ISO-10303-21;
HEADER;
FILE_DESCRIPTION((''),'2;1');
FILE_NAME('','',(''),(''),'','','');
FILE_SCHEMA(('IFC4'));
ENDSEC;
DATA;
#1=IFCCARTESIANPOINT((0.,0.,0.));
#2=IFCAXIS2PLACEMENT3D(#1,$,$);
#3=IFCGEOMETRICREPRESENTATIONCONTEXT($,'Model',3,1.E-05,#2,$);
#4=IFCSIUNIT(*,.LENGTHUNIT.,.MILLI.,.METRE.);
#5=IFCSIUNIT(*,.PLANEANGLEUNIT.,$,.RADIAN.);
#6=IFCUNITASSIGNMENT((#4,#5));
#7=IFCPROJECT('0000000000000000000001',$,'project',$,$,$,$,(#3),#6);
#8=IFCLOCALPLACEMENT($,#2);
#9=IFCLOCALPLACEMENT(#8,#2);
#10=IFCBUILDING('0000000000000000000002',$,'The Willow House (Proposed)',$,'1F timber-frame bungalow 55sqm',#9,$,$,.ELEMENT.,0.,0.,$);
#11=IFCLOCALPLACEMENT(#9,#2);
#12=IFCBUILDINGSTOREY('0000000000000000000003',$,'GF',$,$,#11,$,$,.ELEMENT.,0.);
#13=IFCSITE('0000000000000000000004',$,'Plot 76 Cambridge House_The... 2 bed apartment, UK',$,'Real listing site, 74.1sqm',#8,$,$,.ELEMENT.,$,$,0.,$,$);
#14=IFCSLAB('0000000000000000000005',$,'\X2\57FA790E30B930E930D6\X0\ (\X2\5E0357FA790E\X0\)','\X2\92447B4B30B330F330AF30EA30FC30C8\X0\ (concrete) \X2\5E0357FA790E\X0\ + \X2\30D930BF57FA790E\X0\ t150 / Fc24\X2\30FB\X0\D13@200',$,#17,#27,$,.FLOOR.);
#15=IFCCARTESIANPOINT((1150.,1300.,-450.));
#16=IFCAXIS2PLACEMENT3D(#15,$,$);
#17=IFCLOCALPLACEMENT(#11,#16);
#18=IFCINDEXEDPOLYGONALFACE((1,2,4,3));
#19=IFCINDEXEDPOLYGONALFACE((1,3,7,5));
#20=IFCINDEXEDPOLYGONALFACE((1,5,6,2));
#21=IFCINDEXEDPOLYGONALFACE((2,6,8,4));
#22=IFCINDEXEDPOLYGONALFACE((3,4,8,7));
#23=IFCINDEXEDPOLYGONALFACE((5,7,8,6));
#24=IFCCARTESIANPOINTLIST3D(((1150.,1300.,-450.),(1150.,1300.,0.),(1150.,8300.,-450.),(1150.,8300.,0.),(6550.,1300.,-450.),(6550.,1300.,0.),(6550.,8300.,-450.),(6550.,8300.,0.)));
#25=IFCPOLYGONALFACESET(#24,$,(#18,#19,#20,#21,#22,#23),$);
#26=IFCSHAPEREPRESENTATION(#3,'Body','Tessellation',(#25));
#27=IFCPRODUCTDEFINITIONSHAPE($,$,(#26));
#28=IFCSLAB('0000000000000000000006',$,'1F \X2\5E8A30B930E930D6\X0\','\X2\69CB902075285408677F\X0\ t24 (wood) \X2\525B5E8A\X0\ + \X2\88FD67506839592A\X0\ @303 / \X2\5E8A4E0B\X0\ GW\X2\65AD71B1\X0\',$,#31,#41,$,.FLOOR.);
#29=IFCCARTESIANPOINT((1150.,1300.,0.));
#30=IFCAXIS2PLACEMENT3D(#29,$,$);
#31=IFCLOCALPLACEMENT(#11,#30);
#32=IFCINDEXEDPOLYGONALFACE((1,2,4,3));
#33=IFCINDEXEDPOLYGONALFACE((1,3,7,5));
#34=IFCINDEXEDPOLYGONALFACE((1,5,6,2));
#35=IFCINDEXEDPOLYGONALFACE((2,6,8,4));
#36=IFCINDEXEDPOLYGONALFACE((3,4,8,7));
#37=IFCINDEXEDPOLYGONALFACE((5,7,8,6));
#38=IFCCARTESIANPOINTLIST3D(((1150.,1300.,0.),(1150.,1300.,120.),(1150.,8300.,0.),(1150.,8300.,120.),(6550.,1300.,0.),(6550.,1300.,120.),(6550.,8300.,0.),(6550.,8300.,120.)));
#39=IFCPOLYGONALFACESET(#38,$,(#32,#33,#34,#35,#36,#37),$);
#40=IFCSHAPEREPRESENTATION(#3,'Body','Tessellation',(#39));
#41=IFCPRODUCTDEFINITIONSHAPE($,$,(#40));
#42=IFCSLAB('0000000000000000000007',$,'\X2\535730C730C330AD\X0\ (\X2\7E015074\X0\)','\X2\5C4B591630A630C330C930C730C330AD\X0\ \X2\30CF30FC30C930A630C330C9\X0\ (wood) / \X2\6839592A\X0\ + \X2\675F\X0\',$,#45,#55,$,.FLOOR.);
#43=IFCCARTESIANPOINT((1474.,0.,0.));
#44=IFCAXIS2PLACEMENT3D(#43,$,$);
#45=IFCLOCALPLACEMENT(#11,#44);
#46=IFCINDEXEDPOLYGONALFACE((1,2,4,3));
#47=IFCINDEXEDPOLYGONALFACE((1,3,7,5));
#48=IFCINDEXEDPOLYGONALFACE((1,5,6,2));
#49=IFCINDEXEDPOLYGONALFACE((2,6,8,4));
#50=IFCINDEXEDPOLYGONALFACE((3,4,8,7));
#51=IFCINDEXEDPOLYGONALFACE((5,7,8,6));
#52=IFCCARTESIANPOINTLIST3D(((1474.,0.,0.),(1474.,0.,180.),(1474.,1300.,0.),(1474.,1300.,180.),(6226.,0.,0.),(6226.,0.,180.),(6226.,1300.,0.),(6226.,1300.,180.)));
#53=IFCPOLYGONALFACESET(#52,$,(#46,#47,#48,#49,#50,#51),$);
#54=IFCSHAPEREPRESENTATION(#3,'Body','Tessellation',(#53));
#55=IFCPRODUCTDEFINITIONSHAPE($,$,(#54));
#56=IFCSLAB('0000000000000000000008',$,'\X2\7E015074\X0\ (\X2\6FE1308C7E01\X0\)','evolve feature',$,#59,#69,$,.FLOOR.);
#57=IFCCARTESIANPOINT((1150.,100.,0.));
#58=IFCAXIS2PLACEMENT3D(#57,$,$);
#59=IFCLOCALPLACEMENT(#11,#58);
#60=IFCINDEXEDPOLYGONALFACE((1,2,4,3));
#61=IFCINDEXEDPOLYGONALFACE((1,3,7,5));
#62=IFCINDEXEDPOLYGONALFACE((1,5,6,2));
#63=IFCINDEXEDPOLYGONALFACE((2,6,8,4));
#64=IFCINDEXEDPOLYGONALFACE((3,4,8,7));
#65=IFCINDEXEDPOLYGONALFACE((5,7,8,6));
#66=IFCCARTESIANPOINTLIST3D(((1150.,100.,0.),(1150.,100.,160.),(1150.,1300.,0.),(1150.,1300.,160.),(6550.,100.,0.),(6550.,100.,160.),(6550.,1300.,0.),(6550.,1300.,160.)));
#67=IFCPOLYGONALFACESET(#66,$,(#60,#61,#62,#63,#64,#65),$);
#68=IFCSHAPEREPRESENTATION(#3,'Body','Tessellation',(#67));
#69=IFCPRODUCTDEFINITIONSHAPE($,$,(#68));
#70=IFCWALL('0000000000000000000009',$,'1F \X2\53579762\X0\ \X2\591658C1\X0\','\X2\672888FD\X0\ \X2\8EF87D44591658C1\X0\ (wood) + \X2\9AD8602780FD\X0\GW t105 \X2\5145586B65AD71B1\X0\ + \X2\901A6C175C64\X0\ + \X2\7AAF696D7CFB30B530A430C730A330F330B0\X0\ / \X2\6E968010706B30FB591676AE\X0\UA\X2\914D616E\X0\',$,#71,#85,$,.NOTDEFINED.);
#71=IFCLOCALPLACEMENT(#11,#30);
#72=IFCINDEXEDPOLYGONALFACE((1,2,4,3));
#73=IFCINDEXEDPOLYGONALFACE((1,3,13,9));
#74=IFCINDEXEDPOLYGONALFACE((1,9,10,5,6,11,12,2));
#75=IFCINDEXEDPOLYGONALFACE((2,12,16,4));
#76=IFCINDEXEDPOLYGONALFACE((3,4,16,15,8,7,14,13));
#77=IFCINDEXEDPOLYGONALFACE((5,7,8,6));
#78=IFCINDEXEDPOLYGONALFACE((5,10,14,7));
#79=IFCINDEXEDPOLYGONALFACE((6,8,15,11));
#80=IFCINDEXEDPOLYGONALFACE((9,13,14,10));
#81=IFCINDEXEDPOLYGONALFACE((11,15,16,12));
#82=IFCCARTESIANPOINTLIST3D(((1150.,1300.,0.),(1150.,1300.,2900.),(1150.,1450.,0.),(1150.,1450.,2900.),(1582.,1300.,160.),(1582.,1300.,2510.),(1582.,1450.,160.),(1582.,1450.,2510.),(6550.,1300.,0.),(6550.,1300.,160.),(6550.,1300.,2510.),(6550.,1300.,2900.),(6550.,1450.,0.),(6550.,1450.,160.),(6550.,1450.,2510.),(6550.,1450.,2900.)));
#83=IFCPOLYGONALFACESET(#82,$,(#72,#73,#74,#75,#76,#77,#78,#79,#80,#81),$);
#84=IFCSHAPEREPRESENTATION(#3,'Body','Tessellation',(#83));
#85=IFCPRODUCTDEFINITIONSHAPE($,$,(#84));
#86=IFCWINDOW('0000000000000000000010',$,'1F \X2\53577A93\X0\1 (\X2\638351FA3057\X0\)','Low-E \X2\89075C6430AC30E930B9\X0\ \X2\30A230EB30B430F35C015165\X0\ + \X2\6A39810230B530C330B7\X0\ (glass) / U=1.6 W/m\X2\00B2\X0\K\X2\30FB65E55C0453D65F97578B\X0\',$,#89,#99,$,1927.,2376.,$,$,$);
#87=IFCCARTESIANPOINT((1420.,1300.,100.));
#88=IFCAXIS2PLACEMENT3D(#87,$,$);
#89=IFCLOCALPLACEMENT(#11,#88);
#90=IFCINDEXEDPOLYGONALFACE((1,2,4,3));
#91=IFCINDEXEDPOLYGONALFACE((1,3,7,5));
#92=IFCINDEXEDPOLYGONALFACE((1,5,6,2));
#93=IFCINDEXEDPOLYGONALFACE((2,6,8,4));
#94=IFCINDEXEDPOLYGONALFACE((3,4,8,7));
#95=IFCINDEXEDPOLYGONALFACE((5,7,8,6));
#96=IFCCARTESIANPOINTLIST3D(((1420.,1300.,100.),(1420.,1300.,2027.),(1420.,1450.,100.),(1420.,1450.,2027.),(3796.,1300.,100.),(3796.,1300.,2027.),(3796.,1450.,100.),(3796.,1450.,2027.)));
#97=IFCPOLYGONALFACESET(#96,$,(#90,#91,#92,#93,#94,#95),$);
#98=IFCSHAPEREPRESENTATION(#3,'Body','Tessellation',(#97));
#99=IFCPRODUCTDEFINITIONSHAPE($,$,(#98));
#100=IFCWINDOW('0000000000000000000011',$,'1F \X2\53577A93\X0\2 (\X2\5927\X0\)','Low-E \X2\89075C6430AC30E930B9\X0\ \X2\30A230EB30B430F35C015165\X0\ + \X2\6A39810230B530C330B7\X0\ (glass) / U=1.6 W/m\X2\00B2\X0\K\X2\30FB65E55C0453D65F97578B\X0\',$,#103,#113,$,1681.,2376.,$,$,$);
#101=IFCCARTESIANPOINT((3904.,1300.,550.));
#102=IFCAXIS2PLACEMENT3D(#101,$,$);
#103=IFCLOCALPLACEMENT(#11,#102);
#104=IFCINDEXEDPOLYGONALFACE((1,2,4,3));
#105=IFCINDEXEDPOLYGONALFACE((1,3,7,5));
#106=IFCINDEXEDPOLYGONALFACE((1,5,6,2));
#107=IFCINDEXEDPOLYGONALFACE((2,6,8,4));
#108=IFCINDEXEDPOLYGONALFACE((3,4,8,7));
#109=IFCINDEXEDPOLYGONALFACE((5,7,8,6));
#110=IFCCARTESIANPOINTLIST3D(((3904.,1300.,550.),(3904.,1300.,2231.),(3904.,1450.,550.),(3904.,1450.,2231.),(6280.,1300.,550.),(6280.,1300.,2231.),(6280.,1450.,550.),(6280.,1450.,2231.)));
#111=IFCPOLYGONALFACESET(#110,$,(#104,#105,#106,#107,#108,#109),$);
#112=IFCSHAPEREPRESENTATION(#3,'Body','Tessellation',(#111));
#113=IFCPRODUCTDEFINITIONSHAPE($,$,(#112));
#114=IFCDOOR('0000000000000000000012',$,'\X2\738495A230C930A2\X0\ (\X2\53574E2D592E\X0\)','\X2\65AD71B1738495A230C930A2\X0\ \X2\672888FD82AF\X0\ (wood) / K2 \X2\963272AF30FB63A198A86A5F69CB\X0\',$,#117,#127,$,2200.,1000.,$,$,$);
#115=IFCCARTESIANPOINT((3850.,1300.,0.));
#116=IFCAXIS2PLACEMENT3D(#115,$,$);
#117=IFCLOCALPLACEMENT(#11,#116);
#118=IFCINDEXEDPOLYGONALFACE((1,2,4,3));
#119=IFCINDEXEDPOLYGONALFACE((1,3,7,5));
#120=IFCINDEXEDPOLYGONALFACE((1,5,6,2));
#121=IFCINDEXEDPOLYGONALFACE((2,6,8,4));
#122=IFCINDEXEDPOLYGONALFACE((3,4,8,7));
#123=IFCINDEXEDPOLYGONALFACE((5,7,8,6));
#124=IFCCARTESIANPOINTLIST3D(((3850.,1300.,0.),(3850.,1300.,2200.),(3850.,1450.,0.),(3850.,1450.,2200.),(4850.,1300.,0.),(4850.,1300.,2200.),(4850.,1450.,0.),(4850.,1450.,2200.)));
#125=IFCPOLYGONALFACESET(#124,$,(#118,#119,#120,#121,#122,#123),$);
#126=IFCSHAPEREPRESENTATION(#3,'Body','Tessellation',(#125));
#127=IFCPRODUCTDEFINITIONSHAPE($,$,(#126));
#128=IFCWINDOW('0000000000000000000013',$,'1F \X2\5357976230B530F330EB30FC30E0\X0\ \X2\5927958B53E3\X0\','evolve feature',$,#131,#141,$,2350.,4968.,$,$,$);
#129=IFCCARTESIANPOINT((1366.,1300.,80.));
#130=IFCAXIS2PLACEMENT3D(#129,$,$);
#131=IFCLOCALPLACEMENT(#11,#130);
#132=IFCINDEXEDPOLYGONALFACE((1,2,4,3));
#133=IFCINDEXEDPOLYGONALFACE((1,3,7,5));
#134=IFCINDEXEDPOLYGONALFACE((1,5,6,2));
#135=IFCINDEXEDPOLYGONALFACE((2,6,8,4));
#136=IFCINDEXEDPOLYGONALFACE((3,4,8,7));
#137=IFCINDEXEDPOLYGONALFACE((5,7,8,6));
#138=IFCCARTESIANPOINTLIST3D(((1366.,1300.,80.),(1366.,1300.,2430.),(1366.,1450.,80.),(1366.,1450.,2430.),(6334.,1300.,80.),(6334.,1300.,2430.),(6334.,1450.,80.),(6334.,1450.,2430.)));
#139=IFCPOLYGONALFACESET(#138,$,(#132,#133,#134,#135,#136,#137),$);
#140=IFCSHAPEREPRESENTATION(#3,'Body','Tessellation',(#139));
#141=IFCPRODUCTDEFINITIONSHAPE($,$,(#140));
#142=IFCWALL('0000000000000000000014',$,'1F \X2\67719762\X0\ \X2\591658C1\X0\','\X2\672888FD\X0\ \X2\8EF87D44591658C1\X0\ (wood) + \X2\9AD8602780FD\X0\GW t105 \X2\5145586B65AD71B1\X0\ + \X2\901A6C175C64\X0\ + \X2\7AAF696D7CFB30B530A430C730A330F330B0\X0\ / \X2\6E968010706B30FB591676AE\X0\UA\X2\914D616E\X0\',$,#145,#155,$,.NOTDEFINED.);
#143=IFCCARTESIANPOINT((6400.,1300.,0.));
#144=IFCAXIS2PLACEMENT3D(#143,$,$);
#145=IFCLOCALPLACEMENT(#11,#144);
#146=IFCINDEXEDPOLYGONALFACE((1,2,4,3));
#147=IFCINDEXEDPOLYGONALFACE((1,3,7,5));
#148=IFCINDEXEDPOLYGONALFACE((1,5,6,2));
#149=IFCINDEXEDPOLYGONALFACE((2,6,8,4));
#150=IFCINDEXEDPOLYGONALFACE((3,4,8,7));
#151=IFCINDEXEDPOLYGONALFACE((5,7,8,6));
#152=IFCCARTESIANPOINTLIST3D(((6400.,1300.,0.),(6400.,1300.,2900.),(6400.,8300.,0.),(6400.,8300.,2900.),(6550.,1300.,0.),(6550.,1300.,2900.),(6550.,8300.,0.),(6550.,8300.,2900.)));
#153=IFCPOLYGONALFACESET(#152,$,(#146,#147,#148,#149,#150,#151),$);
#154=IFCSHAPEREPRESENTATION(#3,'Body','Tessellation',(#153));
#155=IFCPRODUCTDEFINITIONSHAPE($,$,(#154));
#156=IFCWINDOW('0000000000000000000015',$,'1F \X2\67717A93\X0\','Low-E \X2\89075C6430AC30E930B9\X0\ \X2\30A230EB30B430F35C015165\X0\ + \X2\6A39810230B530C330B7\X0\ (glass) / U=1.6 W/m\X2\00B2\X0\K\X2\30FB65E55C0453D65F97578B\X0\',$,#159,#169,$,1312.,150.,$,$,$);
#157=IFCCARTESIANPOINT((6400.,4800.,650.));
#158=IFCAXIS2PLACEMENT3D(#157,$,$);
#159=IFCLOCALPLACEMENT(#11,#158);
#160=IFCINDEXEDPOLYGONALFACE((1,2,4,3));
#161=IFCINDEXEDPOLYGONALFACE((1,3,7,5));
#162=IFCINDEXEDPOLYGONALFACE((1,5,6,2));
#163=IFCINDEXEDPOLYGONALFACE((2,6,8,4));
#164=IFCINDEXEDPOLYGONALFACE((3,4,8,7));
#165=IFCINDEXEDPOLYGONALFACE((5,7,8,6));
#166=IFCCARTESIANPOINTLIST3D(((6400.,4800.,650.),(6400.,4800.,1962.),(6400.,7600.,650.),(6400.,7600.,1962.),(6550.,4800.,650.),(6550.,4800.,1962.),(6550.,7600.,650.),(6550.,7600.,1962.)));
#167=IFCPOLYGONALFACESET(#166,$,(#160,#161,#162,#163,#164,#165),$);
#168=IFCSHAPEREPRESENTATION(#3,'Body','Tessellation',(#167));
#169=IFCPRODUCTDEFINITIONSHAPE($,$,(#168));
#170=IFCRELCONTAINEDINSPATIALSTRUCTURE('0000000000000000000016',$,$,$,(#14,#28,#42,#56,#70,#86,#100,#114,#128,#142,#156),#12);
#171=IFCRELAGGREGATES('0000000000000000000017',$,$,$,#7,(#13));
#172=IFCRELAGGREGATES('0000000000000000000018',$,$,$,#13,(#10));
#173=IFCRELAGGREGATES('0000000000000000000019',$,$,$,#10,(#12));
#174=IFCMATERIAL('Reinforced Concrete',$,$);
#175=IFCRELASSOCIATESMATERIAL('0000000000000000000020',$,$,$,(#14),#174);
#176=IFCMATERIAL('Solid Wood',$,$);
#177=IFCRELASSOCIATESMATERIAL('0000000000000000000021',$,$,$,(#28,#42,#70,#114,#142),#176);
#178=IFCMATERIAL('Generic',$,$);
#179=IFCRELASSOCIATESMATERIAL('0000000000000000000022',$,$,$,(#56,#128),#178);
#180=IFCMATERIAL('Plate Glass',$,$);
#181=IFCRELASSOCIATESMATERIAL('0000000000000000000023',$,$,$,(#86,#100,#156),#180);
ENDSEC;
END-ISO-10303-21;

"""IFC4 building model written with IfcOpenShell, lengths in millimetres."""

from ifc_helpers import new_model, si_unit, frame, frame_2d, origin, place, context, project, spatial, rectangle, extrude, material, element, fill, save


model = new_model("IFC4")

# Units and contexts
model_context = context("Model", 3, precision=1e-05, world=origin())
ifc_project = project(units=[si_unit("LENGTHUNIT", "METRE", prefix="MILLI"), si_unit("PLANEANGLEUNIT", "RADIAN")], contexts=[model_context])

# Site, building, storey
site_placement = place(None, origin())
site = spatial("IfcSite", under=ifc_project, at=site_placement, Name="Plot 76 Cambridge House_The... 2 bed apartment, UK", ObjectType="Real listing site, 74.1sqm", CompositionType="ELEMENT", RefElevation=0.0)
building_placement = place(site_placement, origin())
building = spatial("IfcBuilding", under=site, at=building_placement, Name="The Willow House (Proposed)", ObjectType="1F timber-frame bungalow 55sqm", CompositionType="ELEMENT", ElevationOfRefHeight=0.0, ElevationOfTerrain=0.0)
storey_placement = place(building_placement, origin())
storey = spatial("IfcBuildingStorey", under=building, at=storey_placement, Name="GF", CompositionType="ELEMENT", Elevation=0.0)

# Slabs
ifc_material_1 = material(Name="Reinforced Concrete")
slab_1_placement = place(storey_placement, frame((1150.0, 1300.0, -450.0)))
element("IfcSlab", 1, at=slab_1_placement, inside=storey, material=ifc_material_1, Name="基礎スラブ (布基礎)", Description="鉄筋コンクリート (concrete) 布基礎 + ベタ基礎 t150 / Fc24・D13@200", PredefinedType="FLOOR", context=model_context, shape_type="SweptSolid", body=[
    extrude(rectangle(XDim=5400.0, YDim=7000.0, at=frame_2d((2700.0, 3500.0))), frame((1150.0, 1300.0, -450.0)), (0.0, 0.0, 1.0), 450.0),
])
ifc_material_2 = material(Name="Solid Wood")
slab_2_placement = place(storey_placement, frame((1150.0, 1300.0, 0.0)))
element("IfcSlab", 2, at=slab_2_placement, inside=storey, material=ifc_material_2, Name="1F 床スラブ", Description="構造用合板 t24 (wood) 剛床 + 製材根太 @303 / 床下 GW断熱", PredefinedType="FLOOR", context=model_context, shape_type="SweptSolid", body=[
    extrude(rectangle(XDim=5400.0, YDim=7000.0, at=frame_2d((2700.0, 3500.0))), frame((1150.0, 1300.0, 0.0)), (0.0, 0.0, 1.0), 120.0),
])
slab_3_placement = place(storey_placement, frame((1474.0, 0.0, 0.0)))
element("IfcSlab", 3, at=slab_3_placement, inside=storey, material=ifc_material_2, Name="南デッキ (縁側)", Description="屋外ウッドデッキ ハードウッド (wood) / 根太 + 束", PredefinedType="FLOOR", context=model_context, shape_type="SweptSolid", body=[
    extrude(rectangle(XDim=4752.0, YDim=1300.0, at=frame_2d((2376.0, 650.0))), frame((1474.0, 0.0, 0.0)), (0.0, 0.0, 1.0), 180.0),
])
ifc_material_3 = material(Name="Generic")
slab_4_placement = place(storey_placement, frame((1150.0, 100.0, 0.0)))
element("IfcSlab", 4, at=slab_4_placement, inside=storey, material=ifc_material_3, Name="縁側 (濡れ縁)", Description="evolve feature", PredefinedType="FLOOR", context=model_context, shape_type="SweptSolid", body=[
    extrude(rectangle(XDim=5400.0, YDim=1200.0, at=frame_2d((2700.0, 600.0))), frame((1150.0, 100.0, 0.0)), (0.0, 0.0, 1.0), 160.0),
])

# Wall, openings, windows, door
wall_1_placement = place(storey_placement, frame((1150.0, 1300.0, 0.0)))
wall_1 = element("IfcWall", 5, at=wall_1_placement, inside=storey, material=ifc_material_2, Name="1F 南面 外壁", Description="木製 軸組外壁 (wood) + 高性能GW t105 充填断熱 + 通気層 + 窯業系サイディング / 準耐火・外皮UA配慮", PredefinedType="NOTDEFINED", context=model_context, shape_type="SweptSolid", body=[
    extrude(rectangle(XDim=5400.0, YDim=150.0, at=frame_2d((2700.0, 75.0))), frame((1150.0, 1300.0, 0.0)), (0.0, 0.0, 1.0), 2900.0),
])
opening_1_placement = place(storey_placement, frame((1420.0, 1300.0, 100.0)))
opening_1 = element("IfcOpeningElement", 6, at=opening_1_placement, cuts=wall_1, PredefinedType="NOTDEFINED", context=model_context, shape_type="SweptSolid", body=[
    extrude(rectangle(XDim=2376.0, YDim=150.0, at=frame_2d((1188.0, 75.0))), frame((1420.0, 1300.0, 100.0)), (0.0, 0.0, 1.0), 1927.0),
])
opening_2_placement = place(storey_placement, frame((3904.0, 1300.0, 550.0)))
opening_2 = element("IfcOpeningElement", 7, at=opening_2_placement, cuts=wall_1, PredefinedType="NOTDEFINED", context=model_context, shape_type="SweptSolid", body=[
    extrude(rectangle(XDim=2376.0, YDim=150.0, at=frame_2d((1188.0, 75.0))), frame((3904.0, 1300.0, 550.0)), (0.0, 0.0, 1.0), 1681.0),
])
opening_3_placement = place(storey_placement, frame((3850.0, 1300.0, 0.0)))
opening_3 = element("IfcOpeningElement", 8, at=opening_3_placement, cuts=wall_1, PredefinedType="NOTDEFINED", context=model_context, shape_type="SweptSolid", body=[
    extrude(rectangle(XDim=1000.0, YDim=150.0, at=frame_2d((500.0, 75.0))), frame((3850.0, 1300.0, 0.0)), (0.0, 0.0, 1.0), 2200.0),
])
opening_4_placement = place(storey_placement, frame((1366.0, 1300.0, 80.0)))
opening_4 = element("IfcOpeningElement", 9, at=opening_4_placement, cuts=wall_1, PredefinedType="NOTDEFINED", context=model_context, shape_type="SweptSolid", body=[
    extrude(rectangle(XDim=4968.0, YDim=150.0, at=frame_2d((2484.0, 75.0))), frame((1366.0, 1300.0, 80.0)), (0.0, 0.0, 1.0), 2350.0),
])
ifc_material_4 = material(Name="Plate Glass")
window_1_placement = place(storey_placement, frame((1420.0, 1300.0, 100.0)))
window_1 = element("IfcWindow", 10, at=window_1_placement, inside=storey, material=ifc_material_4, Name="1F 南窓1 (掃出し)", Description="Low-E 複層ガラス アルゴン封入 + 樹脂サッシ (glass) / U=1.6 W/m²K・日射取得型", OverallHeight=1927.0, OverallWidth=2376.0, context=model_context, shape_type="SweptSolid", body=[
    extrude(rectangle(XDim=2376.0, YDim=150.0, at=frame_2d((1188.0, 75.0))), frame((1420.0, 1300.0, 100.0)), (0.0, 0.0, 1.0), 1927.0),
])
fill(opening_1, window_1)
window_2_placement = place(storey_placement, frame((3904.0, 1300.0, 550.0)))
window_2 = element("IfcWindow", 11, at=window_2_placement, inside=storey, material=ifc_material_4, Name="1F 南窓2 (大)", Description="Low-E 複層ガラス アルゴン封入 + 樹脂サッシ (glass) / U=1.6 W/m²K・日射取得型", OverallHeight=1681.0, OverallWidth=2376.0, context=model_context, shape_type="SweptSolid", body=[
    extrude(rectangle(XDim=2376.0, YDim=150.0, at=frame_2d((1188.0, 75.0))), frame((3904.0, 1300.0, 550.0)), (0.0, 0.0, 1.0), 1681.0),
])
fill(opening_2, window_2)
door_placement = place(storey_placement, frame((3850.0, 1300.0, 0.0)))
door = element("IfcDoor", 12, at=door_placement, inside=storey, material=ifc_material_2, Name="玄関ドア (南中央)", Description="断熱玄関ドア 木製芯 (wood) / K2 防犯・採風機構", OverallHeight=2200.0, OverallWidth=1000.0, context=model_context, shape_type="SweptSolid", body=[
    extrude(rectangle(XDim=1000.0, YDim=150.0, at=frame_2d((500.0, 75.0))), frame((3850.0, 1300.0, 0.0)), (0.0, 0.0, 1.0), 2200.0),
])
fill(opening_3, door)
window_3_placement = place(storey_placement, frame((1366.0, 1300.0, 80.0)))
window_3 = element("IfcWindow", 13, at=window_3_placement, inside=storey, material=ifc_material_3, Name="1F 南面サンルーム 大開口", Description="evolve feature", OverallHeight=2350.0, OverallWidth=4968.0, context=model_context, shape_type="SweptSolid", body=[
    extrude(rectangle(XDim=4968.0, YDim=150.0, at=frame_2d((2484.0, 75.0))), frame((1366.0, 1300.0, 80.0)), (0.0, 0.0, 1.0), 2350.0),
])
fill(opening_4, window_3)

# Wall, opening, window
wall_2_placement = place(storey_placement, frame((6400.0, 1300.0, 0.0)))
wall_2 = element("IfcWall", 14, at=wall_2_placement, inside=storey, material=ifc_material_2, Name="1F 東面 外壁", Description="木製 軸組外壁 (wood) + 高性能GW t105 充填断熱 + 通気層 + 窯業系サイディング / 準耐火・外皮UA配慮", PredefinedType="NOTDEFINED", context=model_context, shape_type="SweptSolid", body=[
    extrude(rectangle(XDim=150.0, YDim=7000.0, at=frame_2d((75.0, 3500.0))), frame((6400.0, 1300.0, 0.0)), (0.0, 0.0, 1.0), 2900.0),
])
opening_5_placement = place(storey_placement, frame((6400.0, 4800.0, 650.0)))
opening_5 = element("IfcOpeningElement", 15, at=opening_5_placement, cuts=wall_2, PredefinedType="NOTDEFINED", context=model_context, shape_type="SweptSolid", body=[
    extrude(rectangle(XDim=150.0, YDim=2800.0, at=frame_2d((75.0, 1400.0))), frame((6400.0, 4800.0, 650.0)), (0.0, 0.0, 1.0), 1312.0),
])
window_4_placement = place(storey_placement, frame((6400.0, 4800.0, 650.0)))
window_4 = element("IfcWindow", 16, at=window_4_placement, inside=storey, material=ifc_material_4, Name="1F 東窓", Description="Low-E 複層ガラス アルゴン封入 + 樹脂サッシ (glass) / U=1.6 W/m²K・日射取得型", OverallHeight=1312.0, OverallWidth=150.0, context=model_context, shape_type="SweptSolid", body=[
    extrude(rectangle(XDim=150.0, YDim=2800.0, at=frame_2d((75.0, 1400.0))), frame((6400.0, 4800.0, 650.0)), (0.0, 0.0, 1.0), 1312.0),
])
fill(opening_5, window_4)

save(model, "model.ifc")
